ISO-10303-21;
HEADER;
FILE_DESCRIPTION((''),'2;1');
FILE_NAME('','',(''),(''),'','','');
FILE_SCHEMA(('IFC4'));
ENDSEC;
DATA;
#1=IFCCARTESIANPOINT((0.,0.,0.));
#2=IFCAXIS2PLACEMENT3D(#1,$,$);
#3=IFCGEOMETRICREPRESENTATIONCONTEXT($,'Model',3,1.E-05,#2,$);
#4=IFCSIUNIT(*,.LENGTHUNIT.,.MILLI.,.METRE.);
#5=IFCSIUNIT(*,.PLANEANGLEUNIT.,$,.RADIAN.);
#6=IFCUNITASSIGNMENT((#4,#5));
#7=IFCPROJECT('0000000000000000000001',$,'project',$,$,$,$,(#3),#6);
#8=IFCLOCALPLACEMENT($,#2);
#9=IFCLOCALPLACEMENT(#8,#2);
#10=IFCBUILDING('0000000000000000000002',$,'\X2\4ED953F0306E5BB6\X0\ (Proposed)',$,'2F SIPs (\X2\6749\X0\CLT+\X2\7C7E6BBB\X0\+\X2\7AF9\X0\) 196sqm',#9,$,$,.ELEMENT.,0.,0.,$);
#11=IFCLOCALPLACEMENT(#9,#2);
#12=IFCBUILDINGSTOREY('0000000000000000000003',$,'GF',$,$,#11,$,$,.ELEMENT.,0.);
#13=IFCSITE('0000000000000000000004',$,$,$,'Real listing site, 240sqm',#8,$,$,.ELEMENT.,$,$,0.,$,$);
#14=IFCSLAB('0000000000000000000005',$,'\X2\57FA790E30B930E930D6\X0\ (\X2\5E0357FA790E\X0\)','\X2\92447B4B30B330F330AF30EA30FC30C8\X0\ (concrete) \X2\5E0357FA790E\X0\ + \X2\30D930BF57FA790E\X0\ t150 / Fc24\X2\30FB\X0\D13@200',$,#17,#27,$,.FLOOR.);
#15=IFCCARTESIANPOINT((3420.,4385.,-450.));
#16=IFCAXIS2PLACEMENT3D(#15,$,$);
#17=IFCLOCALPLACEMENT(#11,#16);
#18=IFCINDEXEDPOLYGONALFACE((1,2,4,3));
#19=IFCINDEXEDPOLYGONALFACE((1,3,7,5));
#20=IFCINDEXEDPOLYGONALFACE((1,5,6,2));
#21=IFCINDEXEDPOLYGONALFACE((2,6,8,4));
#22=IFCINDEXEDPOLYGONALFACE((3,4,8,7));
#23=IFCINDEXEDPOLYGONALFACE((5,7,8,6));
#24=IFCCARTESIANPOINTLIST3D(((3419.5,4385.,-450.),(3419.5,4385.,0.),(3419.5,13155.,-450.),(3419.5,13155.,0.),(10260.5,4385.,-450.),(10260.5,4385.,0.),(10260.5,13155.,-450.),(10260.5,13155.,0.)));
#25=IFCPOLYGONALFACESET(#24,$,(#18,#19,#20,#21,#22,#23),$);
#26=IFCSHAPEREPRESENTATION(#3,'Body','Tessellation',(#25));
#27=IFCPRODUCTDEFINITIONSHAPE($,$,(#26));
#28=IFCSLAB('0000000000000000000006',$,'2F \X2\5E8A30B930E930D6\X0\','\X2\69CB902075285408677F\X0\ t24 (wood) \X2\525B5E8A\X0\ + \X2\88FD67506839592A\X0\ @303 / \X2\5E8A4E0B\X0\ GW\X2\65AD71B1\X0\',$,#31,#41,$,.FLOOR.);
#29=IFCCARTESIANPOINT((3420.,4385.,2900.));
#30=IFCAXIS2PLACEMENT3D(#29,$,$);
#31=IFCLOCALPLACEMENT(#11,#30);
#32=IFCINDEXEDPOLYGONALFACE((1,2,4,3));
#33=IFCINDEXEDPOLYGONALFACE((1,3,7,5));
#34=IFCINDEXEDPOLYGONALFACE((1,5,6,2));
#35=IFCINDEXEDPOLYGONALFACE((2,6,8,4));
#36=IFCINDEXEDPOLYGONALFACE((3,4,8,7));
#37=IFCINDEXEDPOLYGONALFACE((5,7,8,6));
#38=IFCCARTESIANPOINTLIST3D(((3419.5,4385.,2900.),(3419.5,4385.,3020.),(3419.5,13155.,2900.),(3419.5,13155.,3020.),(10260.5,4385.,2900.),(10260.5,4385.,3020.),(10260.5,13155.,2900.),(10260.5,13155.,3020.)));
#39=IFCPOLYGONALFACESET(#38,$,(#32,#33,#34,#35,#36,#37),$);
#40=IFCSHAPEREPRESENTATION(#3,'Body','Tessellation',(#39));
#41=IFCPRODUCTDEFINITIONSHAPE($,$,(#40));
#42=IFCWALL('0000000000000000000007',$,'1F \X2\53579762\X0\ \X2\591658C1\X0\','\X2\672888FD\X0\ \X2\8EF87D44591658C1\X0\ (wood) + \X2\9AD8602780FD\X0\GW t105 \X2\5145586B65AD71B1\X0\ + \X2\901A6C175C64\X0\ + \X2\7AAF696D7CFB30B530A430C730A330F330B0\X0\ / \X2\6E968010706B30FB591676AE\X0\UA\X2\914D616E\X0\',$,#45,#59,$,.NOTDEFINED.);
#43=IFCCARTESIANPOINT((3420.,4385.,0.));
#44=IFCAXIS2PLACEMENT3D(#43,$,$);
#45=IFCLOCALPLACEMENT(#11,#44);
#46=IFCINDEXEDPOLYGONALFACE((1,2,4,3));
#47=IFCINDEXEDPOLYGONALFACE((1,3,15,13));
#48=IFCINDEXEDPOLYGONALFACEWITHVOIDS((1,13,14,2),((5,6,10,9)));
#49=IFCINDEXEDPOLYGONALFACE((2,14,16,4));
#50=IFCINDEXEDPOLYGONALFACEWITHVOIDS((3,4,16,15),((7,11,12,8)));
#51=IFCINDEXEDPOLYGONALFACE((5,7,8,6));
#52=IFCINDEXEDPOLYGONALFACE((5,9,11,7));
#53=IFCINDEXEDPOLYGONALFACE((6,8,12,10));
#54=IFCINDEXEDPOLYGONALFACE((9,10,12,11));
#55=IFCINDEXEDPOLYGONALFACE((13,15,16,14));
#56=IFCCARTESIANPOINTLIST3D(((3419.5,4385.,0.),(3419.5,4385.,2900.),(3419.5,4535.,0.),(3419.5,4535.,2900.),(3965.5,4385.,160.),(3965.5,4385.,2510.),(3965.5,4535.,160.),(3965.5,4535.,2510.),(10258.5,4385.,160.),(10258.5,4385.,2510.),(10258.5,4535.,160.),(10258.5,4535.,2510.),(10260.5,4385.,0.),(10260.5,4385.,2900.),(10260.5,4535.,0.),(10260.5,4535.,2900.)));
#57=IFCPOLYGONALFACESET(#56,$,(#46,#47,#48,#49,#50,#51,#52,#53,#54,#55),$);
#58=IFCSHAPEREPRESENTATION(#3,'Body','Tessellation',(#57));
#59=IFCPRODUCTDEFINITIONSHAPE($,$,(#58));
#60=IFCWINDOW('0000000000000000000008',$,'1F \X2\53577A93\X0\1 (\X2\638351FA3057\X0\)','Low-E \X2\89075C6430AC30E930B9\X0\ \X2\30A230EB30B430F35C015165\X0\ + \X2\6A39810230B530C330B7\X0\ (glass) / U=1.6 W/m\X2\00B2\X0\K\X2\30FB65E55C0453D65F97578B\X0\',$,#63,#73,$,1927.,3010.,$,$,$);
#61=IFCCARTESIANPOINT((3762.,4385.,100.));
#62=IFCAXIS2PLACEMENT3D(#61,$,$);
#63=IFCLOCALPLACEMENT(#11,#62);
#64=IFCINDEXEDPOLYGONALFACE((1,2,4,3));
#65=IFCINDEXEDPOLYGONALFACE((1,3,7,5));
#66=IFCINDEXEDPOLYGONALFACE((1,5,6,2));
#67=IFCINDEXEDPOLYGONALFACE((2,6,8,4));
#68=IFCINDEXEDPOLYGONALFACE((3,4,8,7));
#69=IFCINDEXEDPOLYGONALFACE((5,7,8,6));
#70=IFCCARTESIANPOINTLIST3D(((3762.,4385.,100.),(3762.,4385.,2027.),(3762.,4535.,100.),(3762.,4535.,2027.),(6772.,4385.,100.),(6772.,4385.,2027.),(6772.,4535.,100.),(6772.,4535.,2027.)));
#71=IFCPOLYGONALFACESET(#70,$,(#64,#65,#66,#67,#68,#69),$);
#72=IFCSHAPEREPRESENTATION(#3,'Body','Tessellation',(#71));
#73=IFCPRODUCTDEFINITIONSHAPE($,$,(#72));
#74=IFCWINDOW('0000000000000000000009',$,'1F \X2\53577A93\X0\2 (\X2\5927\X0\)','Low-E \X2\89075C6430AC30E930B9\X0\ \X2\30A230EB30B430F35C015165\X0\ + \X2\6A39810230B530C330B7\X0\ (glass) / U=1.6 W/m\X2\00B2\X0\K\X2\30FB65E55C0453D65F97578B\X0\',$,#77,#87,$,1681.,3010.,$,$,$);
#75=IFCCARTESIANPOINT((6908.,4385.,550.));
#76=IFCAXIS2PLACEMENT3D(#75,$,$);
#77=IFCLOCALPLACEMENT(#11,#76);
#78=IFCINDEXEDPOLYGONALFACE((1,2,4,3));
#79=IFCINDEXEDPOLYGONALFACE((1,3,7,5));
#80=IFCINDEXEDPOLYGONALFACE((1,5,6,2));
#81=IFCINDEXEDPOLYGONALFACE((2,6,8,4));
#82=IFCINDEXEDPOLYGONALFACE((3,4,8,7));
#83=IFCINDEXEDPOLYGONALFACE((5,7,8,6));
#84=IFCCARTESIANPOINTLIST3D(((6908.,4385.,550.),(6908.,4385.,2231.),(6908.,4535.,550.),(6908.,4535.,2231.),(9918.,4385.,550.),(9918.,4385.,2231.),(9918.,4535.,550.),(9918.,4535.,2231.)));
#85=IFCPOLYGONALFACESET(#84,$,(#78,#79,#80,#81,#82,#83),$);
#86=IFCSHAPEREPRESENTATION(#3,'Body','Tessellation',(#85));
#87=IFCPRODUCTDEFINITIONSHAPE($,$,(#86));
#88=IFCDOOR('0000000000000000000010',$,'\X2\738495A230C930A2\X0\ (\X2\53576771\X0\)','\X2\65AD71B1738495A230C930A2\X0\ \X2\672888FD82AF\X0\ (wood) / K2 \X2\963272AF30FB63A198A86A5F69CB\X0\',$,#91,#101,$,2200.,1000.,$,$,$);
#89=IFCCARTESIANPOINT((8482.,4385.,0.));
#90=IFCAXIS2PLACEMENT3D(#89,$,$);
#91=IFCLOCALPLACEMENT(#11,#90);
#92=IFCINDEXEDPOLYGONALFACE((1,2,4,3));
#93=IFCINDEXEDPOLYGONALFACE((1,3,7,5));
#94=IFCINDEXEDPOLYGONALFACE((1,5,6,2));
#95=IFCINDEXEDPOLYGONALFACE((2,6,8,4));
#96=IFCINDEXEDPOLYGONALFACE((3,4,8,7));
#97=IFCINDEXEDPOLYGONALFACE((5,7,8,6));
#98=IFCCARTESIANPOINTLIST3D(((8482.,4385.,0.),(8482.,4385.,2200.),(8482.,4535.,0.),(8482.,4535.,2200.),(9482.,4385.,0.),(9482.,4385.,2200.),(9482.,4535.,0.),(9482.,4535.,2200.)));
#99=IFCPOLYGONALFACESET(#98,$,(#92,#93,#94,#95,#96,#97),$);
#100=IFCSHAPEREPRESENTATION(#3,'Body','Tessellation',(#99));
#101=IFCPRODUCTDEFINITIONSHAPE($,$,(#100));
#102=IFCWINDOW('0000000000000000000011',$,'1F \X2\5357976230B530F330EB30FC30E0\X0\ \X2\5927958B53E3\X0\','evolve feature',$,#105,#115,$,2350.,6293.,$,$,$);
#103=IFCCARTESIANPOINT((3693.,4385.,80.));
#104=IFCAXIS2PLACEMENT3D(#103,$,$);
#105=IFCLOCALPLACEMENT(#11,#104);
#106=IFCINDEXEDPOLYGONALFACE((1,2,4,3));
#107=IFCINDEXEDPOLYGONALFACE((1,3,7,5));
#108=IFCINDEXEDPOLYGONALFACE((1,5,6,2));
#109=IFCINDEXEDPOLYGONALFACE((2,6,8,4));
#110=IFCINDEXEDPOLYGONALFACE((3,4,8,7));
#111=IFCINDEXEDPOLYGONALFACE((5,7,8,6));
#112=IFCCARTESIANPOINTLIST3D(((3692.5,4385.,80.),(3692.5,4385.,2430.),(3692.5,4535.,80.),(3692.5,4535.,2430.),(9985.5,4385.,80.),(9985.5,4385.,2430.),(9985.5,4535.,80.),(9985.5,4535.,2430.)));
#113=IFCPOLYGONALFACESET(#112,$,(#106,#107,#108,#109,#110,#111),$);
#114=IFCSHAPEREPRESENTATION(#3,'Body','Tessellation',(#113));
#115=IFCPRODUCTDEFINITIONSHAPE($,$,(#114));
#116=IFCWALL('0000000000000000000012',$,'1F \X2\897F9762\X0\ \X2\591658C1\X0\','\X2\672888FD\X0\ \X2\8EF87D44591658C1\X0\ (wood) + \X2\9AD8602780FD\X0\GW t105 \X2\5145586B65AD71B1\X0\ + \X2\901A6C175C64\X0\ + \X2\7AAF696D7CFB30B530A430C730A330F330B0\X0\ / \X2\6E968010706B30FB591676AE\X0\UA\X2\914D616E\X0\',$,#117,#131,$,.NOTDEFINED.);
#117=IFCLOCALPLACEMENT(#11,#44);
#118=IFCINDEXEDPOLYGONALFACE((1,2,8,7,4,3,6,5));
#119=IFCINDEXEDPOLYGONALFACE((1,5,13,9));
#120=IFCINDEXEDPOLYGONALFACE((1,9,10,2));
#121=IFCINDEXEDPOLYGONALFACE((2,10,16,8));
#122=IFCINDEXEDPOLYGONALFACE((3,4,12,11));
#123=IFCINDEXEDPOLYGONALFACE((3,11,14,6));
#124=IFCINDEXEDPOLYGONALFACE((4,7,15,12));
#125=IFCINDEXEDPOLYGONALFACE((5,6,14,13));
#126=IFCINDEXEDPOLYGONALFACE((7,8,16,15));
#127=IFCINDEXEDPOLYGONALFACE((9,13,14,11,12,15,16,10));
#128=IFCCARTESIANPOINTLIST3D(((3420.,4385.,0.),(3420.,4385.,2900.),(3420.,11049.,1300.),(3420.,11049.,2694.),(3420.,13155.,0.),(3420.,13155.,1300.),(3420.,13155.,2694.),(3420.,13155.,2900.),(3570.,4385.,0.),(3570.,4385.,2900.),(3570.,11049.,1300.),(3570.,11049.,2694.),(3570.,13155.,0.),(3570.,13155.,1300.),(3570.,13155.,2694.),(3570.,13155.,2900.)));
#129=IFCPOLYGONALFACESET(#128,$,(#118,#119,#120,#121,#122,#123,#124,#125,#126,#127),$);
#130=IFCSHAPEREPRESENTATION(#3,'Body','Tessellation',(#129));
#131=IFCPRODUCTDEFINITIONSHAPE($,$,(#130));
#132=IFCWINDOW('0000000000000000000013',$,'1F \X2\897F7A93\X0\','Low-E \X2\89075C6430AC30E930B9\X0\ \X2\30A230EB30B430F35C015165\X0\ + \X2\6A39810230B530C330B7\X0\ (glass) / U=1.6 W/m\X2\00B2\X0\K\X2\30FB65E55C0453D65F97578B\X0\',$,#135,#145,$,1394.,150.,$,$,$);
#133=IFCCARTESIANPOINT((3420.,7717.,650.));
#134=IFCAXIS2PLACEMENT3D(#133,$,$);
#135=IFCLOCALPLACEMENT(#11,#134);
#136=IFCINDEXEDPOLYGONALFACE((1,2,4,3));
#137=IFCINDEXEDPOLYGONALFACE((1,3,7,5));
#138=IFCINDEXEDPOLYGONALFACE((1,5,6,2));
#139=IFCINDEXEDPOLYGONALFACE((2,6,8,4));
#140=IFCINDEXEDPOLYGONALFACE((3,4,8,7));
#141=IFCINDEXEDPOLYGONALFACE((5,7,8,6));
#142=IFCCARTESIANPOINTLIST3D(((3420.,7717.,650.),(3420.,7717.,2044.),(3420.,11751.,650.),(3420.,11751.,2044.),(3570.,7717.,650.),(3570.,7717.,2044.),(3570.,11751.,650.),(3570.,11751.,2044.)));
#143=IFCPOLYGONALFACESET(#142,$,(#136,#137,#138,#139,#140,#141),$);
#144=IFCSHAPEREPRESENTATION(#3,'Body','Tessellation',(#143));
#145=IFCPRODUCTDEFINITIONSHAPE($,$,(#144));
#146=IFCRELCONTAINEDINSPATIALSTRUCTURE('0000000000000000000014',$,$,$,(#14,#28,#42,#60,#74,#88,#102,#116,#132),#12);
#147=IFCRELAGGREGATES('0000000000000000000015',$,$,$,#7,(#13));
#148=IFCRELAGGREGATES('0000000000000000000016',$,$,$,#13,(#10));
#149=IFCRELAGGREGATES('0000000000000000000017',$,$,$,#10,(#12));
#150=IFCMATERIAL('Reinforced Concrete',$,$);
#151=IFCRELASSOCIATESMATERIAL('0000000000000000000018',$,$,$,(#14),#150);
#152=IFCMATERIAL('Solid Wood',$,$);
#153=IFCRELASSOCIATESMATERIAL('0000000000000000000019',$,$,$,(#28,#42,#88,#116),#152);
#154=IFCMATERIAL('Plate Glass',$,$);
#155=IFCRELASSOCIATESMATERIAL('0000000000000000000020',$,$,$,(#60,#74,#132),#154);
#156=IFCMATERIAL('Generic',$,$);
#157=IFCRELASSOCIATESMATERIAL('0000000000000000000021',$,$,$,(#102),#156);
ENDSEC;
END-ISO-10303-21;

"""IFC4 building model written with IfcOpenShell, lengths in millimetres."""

from ifc_helpers import new_model, si_unit, frame, frame_2d, origin, place, context, project, spatial, rectangle, extrude, material, element, fill, save


model = new_model("IFC4")

# Units and contexts
model_context = context("Model", 3, precision=1e-05, world=origin())
ifc_project = project(units=[si_unit("LENGTHUNIT", "METRE", prefix="MILLI"), si_unit("PLANEANGLEUNIT", "RADIAN")], contexts=[model_context])

# Site, building, storey
site_placement = place(None, origin())
site = spatial("IfcSite", under=ifc_project, at=site_placement, ObjectType="Real listing site, 240sqm", CompositionType="ELEMENT", RefElevation=0.0)
building_placement = place(site_placement, origin())
building = spatial("IfcBuilding", under=site, at=building_placement, Name="仙台の家 (Proposed)", ObjectType="2F SIPs (杉CLT+籾殻+竹) 196sqm", CompositionType="ELEMENT", ElevationOfRefHeight=0.0, ElevationOfTerrain=0.0)
storey_placement = place(building_placement, origin())
storey = spatial("IfcBuildingStorey", under=building, at=storey_placement, Name="GF", CompositionType="ELEMENT", Elevation=0.0)

# Slabs
ifc_material_1 = material(Name="Reinforced Concrete")
slab_1_placement = place(storey_placement, frame((3420.0, 4385.0, -450.0)))
element("IfcSlab", 1, at=slab_1_placement, inside=storey, material=ifc_material_1, Name="基礎スラブ (布基礎)", Description="鉄筋コンクリート (concrete) 布基礎 + ベタ基礎 t150 / Fc24・D13@200", PredefinedType="FLOOR", context=model_context, shape_type="SweptSolid", body=[
    extrude(rectangle(XDim=6841.0, YDim=8770.0, at=frame_2d((3420.0, 4385.0))), frame((3420.0, 4385.0, -450.0)), (0.0, 0.0, 1.0), 450.0),
])
ifc_material_2 = material(Name="Solid Wood")
slab_2_placement = place(storey_placement, frame((3420.0, 4385.0, 2900.0)))
element("IfcSlab", 2, at=slab_2_placement, inside=storey, material=ifc_material_2, Name="2F 床スラブ", Description="構造用合板 t24 (wood) 剛床 + 製材根太 @303 / 床下 GW断熱", PredefinedType="FLOOR", context=model_context, shape_type="SweptSolid", body=[
    extrude(rectangle(XDim=6841.0, YDim=8770.0, at=frame_2d((3420.0, 4385.0))), frame((3420.0, 4385.0, 2900.0)), (0.0, 0.0, 1.0), 120.0),
])

# Wall, openings, windows, door
wall_1_placement = place(storey_placement, frame((3420.0, 4385.0, 0.0)))
wall_1 = element("IfcWall", 3, at=wall_1_placement, inside=storey, material=ifc_material_2, Name="1F 南面 外壁", Description="木製 軸組外壁 (wood) + 高性能GW t105 充填断熱 + 通気層 + 窯業系サイディング / 準耐火・外皮UA配慮", PredefinedType="NOTDEFINED", context=model_context, shape_type="SweptSolid", body=[
    extrude(rectangle(XDim=6841.0, YDim=150.0, at=frame_2d((3420.0, 75.0))), frame((3420.0, 4385.0, 0.0)), (0.0, 0.0, 1.0), 2900.0),
])
opening_1_placement = place(storey_placement, frame((3762.0, 4385.0, 100.0)))
opening_1 = element("IfcOpeningElement", 4, at=opening_1_placement, cuts=wall_1, PredefinedType="NOTDEFINED", context=model_context, shape_type="SweptSolid", body=[
    extrude(rectangle(XDim=3010.0, YDim=150.0, at=frame_2d((1505.0, 75.0))), frame((3762.0, 4385.0, 100.0)), (0.0, 0.0, 1.0), 1927.0),
])
opening_2_placement = place(storey_placement, frame((6908.0, 4385.0, 550.0)))
opening_2 = element("IfcOpeningElement", 5, at=opening_2_placement, cuts=wall_1, PredefinedType="NOTDEFINED", context=model_context, shape_type="SweptSolid", body=[
    extrude(rectangle(XDim=3010.0, YDim=150.0, at=frame_2d((1505.0, 75.0))), frame((6908.0, 4385.0, 550.0)), (0.0, 0.0, 1.0), 1681.0),
])
opening_3_placement = place(storey_placement, frame((8482.0, 4385.0, 0.0)))
opening_3 = element("IfcOpeningElement", 6, at=opening_3_placement, cuts=wall_1, PredefinedType="NOTDEFINED", context=model_context, shape_type="SweptSolid", body=[
    extrude(rectangle(XDim=1000.0, YDim=150.0, at=frame_2d((500.0, 75.0))), frame((8482.0, 4385.0, 0.0)), (0.0, 0.0, 1.0), 2200.0),
])
opening_4_placement = place(storey_placement, frame((3693.0, 4385.0, 80.0)))
opening_4 = element("IfcOpeningElement", 7, at=opening_4_placement, cuts=wall_1, PredefinedType="NOTDEFINED", context=model_context, shape_type="SweptSolid", body=[
    extrude(rectangle(XDim=6293.0, YDim=150.0, at=frame_2d((3146.0, 75.0))), frame((3693.0, 4385.0, 80.0)), (0.0, 0.0, 1.0), 2350.0),
])
ifc_material_3 = material(Name="Plate Glass")
window_1_placement = place(storey_placement, frame((3762.0, 4385.0, 100.0)))
window_1 = element("IfcWindow", 8, at=window_1_placement, inside=storey, material=ifc_material_3, Name="1F 南窓1 (掃出し)", Description="Low-E 複層ガラス アルゴン封入 + 樹脂サッシ (glass) / U=1.6 W/m²K・日射取得型", OverallHeight=1927.0, OverallWidth=3010.0, context=model_context, shape_type="SweptSolid", body=[
    extrude(rectangle(XDim=3010.0, YDim=150.0, at=frame_2d((1505.0, 75.0))), frame((3762.0, 4385.0, 100.0)), (0.0, 0.0, 1.0), 1927.0),
])
fill(opening_1, window_1)
window_2_placement = place(storey_placement, frame((6908.0, 4385.0, 550.0)))
window_2 = element("IfcWindow", 9, at=window_2_placement, inside=storey, material=ifc_material_3, Name="1F 南窓2 (大)", Description="Low-E 複層ガラス アルゴン封入 + 樹脂サッシ (glass) / U=1.6 W/m²K・日射取得型", OverallHeight=1681.0, OverallWidth=3010.0, context=model_context, shape_type="SweptSolid", body=[
    extrude(rectangle(XDim=3010.0, YDim=150.0, at=frame_2d((1505.0, 75.0))), frame((6908.0, 4385.0, 550.0)), (0.0, 0.0, 1.0), 1681.0),
])
fill(opening_2, window_2)
door_placement = place(storey_placement, frame((8482.0, 4385.0, 0.0)))
door = element("IfcDoor", 10, at=door_placement, inside=storey, material=ifc_material_2, Name="玄関ドア (南東)", Description="断熱玄関ドア 木製芯 (wood) / K2 防犯・採風機構", OverallHeight=2200.0, OverallWidth=1000.0, context=model_context, shape_type="SweptSolid", body=[
    extrude(rectangle(XDim=1000.0, YDim=150.0, at=frame_2d((500.0, 75.0))), frame((8482.0, 4385.0, 0.0)), (0.0, 0.0, 1.0), 2200.0),
])
fill(opening_3, door)
ifc_material_4 = material(Name="Generic")
window_3_placement = place(storey_placement, frame((3693.0, 4385.0, 80.0)))
window_3 = element("IfcWindow", 11, at=window_3_placement, inside=storey, material=ifc_material_4, Name="1F 南面サンルーム 大開口", Description="evolve feature", OverallHeight=2350.0, OverallWidth=6293.0, context=model_context, shape_type="SweptSolid", body=[
    extrude(rectangle(XDim=6293.0, YDim=150.0, at=frame_2d((3146.0, 75.0))), frame((3693.0, 4385.0, 80.0)), (0.0, 0.0, 1.0), 2350.0),
])
fill(opening_4, window_3)

# Wall, opening, window
wall_2_placement = place(storey_placement, frame((3420.0, 4385.0, 0.0)))
wall_2 = element("IfcWall", 12, at=wall_2_placement, inside=storey, material=ifc_material_2, Name="1F 西面 外壁", Description="木製 軸組外壁 (wood) + 高性能GW t105 充填断熱 + 通気層 + 窯業系サイディング / 準耐火・外皮UA配慮", PredefinedType="NOTDEFINED", context=model_context, shape_type="SweptSolid", body=[
    extrude(rectangle(XDim=150.0, YDim=8770.0, at=frame_2d((75.0, 4385.0))), frame((3420.0, 4385.0, 0.0)), (0.0, 0.0, 1.0), 2900.0),
])
opening_5_placement = place(storey_placement, frame((3420.0, 7717.0, 650.0)))
opening_5 = element("IfcOpeningElement", 13, at=opening_5_placement, cuts=wall_2, PredefinedType="NOTDEFINED", context=model_context, shape_type="SweptSolid", body=[
    extrude(rectangle(XDim=150.0, YDim=4034.0, at=frame_2d((75.0, 2017.0))), frame((3420.0, 7717.0, 650.0)), (0.0, 0.0, 1.0), 1394.0),
])
window_4_placement = place(storey_placement, frame((3420.0, 7717.0, 650.0)))
window_4 = element("IfcWindow", 14, at=window_4_placement, inside=storey, material=ifc_material_3, Name="1F 西窓", Description="Low-E 複層ガラス アルゴン封入 + 樹脂サッシ (glass) / U=1.6 W/m²K・日射取得型", OverallHeight=1394.0, OverallWidth=150.0, context=model_context, shape_type="SweptSolid", body=[
    extrude(rectangle(XDim=150.0, YDim=4034.0, at=frame_2d((75.0, 2017.0))), frame((3420.0, 7717.0, 650.0)), (0.0, 0.0, 1.0), 1394.0),
])
fill(opening_5, window_4)

save(model, "model.ifc")
